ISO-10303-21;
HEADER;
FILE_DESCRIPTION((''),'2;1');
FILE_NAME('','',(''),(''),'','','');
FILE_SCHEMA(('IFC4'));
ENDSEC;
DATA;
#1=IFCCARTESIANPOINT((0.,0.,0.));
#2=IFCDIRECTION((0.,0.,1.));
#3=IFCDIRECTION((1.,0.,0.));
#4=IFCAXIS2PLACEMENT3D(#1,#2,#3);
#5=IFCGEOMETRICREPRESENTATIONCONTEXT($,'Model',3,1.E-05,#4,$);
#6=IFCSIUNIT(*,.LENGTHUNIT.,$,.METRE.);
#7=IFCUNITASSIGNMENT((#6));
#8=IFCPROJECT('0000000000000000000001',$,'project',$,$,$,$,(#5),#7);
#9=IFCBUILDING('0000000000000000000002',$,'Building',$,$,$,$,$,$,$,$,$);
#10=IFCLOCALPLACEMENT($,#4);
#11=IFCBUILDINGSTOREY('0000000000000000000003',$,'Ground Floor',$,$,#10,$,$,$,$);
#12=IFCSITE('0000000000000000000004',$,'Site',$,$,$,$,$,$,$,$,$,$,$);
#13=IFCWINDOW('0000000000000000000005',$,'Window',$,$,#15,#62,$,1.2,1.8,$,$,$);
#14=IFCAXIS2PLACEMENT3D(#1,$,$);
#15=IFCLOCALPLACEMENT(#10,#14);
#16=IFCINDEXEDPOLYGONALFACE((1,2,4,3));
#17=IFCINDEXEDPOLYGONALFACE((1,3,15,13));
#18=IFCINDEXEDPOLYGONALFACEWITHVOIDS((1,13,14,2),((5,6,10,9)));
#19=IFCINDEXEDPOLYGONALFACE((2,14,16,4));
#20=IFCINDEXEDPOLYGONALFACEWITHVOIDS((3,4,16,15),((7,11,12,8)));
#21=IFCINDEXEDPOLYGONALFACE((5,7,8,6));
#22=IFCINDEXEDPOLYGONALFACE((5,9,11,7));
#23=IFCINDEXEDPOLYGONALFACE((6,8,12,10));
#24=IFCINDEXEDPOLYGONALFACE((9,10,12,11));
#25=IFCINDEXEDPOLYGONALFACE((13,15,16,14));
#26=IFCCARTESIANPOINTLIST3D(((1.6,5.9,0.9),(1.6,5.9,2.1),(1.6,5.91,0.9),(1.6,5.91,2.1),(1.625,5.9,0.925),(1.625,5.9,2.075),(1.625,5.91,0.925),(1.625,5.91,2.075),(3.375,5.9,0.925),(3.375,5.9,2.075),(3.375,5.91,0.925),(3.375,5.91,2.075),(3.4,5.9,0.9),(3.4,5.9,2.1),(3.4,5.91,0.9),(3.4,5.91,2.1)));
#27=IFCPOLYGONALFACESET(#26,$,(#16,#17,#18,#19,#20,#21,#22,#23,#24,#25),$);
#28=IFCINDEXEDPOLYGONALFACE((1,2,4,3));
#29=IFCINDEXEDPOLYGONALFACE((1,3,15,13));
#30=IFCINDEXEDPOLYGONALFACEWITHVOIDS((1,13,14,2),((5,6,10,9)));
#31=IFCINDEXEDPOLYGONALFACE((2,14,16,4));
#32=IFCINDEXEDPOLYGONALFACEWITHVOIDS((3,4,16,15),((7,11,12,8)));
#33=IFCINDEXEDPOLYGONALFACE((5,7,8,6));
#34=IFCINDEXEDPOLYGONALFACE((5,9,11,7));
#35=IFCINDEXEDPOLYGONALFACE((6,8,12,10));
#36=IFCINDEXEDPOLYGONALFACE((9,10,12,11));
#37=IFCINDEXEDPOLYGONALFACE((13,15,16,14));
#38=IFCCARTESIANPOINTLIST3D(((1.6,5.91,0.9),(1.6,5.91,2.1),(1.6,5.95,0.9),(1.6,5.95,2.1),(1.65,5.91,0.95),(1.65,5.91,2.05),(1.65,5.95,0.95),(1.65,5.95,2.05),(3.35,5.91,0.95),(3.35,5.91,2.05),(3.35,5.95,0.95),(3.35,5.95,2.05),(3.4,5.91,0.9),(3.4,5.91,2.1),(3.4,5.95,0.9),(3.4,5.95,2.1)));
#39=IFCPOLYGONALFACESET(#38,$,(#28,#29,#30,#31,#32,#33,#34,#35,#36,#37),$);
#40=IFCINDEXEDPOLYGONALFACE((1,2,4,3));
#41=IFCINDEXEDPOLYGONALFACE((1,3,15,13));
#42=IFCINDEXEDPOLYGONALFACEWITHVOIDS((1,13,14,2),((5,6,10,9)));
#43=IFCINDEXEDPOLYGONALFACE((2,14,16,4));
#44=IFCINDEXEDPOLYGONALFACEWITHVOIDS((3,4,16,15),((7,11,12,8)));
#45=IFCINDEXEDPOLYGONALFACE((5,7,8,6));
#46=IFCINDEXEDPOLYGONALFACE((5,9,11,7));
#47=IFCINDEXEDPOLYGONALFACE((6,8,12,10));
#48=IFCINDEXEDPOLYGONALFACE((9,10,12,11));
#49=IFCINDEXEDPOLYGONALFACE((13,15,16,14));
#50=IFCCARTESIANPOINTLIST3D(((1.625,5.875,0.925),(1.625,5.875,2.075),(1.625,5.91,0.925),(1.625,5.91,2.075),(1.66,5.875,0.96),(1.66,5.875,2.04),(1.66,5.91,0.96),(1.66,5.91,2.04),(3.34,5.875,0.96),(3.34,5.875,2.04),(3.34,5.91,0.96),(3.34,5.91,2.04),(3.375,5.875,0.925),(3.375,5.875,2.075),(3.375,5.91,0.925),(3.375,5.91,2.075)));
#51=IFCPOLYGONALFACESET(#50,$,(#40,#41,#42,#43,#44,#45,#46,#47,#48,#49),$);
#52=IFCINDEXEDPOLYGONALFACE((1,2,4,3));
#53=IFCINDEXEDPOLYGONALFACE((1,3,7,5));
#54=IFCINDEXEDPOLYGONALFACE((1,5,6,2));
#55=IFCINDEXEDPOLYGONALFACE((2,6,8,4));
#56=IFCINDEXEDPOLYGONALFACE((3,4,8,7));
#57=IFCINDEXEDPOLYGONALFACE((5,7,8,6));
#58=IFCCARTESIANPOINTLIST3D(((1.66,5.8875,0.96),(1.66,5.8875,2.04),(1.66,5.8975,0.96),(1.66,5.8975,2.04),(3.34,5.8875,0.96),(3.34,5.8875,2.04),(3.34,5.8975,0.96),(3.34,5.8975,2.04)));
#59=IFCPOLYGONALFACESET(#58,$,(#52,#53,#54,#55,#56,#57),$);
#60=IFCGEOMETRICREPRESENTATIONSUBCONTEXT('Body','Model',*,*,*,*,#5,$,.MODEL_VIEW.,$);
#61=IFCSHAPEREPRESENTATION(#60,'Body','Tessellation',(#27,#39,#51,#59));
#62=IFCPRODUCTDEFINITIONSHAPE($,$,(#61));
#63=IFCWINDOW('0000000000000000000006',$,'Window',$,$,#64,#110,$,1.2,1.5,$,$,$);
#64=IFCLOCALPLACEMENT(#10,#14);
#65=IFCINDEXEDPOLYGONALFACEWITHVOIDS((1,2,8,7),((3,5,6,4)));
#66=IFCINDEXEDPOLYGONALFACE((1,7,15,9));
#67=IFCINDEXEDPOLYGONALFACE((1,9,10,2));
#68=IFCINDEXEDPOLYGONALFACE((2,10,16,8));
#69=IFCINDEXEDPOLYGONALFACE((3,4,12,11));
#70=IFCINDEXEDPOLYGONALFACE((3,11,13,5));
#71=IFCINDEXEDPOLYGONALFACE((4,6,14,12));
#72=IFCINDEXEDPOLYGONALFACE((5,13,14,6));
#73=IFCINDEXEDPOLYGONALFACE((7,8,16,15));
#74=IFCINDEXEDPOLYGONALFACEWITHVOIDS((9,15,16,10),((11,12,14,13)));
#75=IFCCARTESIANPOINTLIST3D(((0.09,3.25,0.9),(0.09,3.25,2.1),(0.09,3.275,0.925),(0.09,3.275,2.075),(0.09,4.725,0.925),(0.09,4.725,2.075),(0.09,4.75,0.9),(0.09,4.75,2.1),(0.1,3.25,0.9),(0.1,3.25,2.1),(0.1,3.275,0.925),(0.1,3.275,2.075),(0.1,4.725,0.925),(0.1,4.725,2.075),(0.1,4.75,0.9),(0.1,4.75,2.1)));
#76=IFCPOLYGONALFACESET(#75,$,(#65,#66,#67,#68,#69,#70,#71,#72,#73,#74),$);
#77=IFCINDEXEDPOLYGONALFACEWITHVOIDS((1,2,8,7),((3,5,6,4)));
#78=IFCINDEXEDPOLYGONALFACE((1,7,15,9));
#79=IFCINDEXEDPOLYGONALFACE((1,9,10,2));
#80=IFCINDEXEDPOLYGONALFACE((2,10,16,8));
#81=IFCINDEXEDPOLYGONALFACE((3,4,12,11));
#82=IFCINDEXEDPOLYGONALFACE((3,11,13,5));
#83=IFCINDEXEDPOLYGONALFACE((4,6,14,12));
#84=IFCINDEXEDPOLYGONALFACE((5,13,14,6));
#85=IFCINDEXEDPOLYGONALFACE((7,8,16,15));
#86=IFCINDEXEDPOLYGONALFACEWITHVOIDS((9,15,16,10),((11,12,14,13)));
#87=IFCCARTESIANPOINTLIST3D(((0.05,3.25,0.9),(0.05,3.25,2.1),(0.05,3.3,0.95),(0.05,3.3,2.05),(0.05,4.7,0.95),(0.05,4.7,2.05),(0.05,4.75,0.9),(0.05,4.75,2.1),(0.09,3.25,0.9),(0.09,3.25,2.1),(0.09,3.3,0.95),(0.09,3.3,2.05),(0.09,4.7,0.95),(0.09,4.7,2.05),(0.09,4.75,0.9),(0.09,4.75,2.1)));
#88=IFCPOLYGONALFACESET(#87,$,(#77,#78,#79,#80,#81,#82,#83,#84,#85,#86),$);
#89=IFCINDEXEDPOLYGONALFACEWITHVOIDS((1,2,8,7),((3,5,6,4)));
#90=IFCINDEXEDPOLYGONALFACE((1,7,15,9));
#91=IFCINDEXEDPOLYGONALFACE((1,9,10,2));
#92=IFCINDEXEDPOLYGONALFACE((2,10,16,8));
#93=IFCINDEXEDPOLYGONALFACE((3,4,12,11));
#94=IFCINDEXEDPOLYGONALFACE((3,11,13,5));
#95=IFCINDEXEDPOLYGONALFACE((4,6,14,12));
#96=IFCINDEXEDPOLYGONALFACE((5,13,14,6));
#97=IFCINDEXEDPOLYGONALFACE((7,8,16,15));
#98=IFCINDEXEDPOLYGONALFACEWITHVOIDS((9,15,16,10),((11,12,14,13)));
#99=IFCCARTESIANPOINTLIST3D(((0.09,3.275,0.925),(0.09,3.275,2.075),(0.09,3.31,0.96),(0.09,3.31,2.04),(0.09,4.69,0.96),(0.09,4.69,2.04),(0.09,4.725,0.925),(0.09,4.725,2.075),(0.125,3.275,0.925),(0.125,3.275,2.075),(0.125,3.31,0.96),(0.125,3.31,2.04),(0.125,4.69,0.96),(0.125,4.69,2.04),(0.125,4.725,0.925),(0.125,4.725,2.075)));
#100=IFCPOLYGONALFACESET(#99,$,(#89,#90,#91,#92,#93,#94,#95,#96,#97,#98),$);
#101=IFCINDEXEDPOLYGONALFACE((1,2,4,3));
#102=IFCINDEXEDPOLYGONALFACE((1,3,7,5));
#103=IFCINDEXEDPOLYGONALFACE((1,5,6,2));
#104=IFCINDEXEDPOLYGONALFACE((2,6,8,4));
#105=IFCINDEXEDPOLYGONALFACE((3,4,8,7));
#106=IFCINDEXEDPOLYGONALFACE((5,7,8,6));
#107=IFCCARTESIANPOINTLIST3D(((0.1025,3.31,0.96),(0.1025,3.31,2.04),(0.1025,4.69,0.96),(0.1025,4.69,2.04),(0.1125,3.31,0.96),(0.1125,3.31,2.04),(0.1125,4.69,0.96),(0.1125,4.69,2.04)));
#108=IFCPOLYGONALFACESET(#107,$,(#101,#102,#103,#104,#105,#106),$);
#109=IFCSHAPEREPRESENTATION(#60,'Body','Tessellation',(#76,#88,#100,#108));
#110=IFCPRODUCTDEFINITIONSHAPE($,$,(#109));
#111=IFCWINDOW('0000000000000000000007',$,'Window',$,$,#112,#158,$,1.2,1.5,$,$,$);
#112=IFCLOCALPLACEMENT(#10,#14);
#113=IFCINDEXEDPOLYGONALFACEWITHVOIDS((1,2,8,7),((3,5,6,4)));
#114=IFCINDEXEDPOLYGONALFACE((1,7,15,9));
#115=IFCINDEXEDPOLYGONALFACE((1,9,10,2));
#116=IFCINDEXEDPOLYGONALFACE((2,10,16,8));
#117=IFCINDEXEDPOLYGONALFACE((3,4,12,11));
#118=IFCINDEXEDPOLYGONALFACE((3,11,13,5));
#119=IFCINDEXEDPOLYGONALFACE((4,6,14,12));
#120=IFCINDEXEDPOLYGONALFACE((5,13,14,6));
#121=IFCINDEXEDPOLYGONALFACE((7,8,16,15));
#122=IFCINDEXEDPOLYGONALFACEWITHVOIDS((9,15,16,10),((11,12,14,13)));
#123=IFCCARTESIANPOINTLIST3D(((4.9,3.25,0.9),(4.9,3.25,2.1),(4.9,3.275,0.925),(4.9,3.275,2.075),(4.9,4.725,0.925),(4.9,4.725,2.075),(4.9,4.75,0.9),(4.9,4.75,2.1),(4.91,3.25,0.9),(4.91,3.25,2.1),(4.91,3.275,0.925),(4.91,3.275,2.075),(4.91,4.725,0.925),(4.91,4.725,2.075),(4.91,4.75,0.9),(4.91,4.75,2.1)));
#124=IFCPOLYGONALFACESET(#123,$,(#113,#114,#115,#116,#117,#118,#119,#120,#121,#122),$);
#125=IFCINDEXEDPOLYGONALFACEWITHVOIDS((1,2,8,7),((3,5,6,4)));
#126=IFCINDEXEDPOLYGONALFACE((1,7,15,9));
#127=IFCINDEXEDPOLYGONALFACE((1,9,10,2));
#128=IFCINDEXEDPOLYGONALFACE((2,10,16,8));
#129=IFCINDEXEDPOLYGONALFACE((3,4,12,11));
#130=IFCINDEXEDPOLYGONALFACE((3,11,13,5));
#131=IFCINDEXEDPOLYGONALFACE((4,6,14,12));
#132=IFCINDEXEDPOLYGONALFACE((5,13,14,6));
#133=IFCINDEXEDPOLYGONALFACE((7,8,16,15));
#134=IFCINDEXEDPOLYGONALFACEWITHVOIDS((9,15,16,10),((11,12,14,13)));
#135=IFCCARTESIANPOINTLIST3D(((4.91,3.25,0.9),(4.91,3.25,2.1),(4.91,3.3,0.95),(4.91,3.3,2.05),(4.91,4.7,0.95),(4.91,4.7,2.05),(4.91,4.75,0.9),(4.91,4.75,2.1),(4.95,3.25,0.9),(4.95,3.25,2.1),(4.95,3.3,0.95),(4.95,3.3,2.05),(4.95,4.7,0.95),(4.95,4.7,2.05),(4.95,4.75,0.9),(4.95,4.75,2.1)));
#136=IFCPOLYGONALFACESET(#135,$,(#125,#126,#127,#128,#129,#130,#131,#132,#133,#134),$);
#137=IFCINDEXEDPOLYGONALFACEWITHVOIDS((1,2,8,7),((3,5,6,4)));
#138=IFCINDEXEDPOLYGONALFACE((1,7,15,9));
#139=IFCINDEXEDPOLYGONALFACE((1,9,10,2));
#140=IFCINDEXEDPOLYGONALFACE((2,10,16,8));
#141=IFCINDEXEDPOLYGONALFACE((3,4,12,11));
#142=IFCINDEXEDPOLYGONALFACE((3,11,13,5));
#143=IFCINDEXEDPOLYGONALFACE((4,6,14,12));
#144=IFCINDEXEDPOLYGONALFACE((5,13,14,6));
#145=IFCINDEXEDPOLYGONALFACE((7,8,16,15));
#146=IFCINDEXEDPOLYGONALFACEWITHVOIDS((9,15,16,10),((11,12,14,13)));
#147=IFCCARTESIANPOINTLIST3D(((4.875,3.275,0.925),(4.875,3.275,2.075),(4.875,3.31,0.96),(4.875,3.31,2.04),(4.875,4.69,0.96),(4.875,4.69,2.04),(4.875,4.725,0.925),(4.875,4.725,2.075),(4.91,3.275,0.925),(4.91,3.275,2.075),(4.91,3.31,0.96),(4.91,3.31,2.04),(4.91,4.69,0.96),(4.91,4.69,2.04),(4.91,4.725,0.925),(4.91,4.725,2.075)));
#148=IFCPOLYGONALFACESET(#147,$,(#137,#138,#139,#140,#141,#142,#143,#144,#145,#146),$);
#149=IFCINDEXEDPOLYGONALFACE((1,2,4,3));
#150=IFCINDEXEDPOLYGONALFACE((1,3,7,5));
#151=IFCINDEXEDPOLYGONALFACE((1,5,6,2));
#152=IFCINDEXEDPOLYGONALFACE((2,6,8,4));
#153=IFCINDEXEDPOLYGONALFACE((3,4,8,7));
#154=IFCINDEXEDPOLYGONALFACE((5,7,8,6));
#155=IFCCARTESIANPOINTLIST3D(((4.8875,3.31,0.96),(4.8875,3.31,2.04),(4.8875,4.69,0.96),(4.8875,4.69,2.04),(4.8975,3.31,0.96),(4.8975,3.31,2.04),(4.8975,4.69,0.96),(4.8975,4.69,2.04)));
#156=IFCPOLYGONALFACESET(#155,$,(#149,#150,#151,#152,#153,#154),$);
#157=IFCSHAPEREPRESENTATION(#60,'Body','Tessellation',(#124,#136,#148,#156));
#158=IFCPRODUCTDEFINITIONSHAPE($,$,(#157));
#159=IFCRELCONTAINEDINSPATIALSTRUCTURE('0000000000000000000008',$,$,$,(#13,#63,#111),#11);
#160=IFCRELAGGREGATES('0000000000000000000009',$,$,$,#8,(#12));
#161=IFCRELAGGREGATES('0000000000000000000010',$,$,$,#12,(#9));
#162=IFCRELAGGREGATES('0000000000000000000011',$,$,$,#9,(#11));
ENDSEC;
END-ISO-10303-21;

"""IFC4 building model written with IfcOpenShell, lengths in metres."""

from ifc_helpers import new_model, si_unit, frame, origin_with_axes, place, context, subcontext, project, spatial, line, indexed_curve, outline, extrude, element, save


model = new_model("IFC4")

# Units and contexts
model_context = context("Model", 3, precision=1e-05, world=origin_with_axes())
body_context = subcontext(model_context, "Body", "Model", "MODEL_VIEW")
ifc_project = project(units=[si_unit("LENGTHUNIT", "METRE")], contexts=[model_context])

# Site, building, storey
site = spatial("IfcSite", under=ifc_project, Name="Site")
building = spatial("IfcBuilding", under=site, Name="Building")
storey_placement = place(None, origin_with_axes())
storey = spatial("IfcBuildingStorey", under=building, at=storey_placement, Name="Ground Floor")

# Windows
window_placement = place(storey_placement, frame((3.4, 6.0, 0.9), z_axis=(0.0, 0.0, 1.0), x_axis=(-1.0, 0.0, 0.0)))
element("IfcWindow", 1, at=window_placement, inside=storey, Name="Window", OverallHeight=1.2, OverallWidth=1.8, context=body_context, shape_type="SweptSolid", body=[
    extrude(outline(indexed_curve([(0.0, 0.0), (1.8, 0.0), (1.8, 1.2), (0.0, 1.2)], segments=[line(1, 2, 3, 4, 1)]), holes=[indexed_curve([(0.025, 0.025), (1.775, 0.025), (1.775, 1.175), (0.025, 1.175)], segments=[line(1, 2, 3, 4, 1)])]), frame((0.0, 0.09, 0.0), z_axis=(0.0, -1.0, 0.0), x_axis=(1.0, 0.0, 0.0)), (0.0, 0.0, -1.0), 0.01),
    extrude(outline(indexed_curve([(0.0, 0.0), (1.8, 0.0), (1.8, 1.2), (0.0, 1.2)], segments=[line(1, 2, 3, 4, 1)]), holes=[indexed_curve([(0.05, 0.05), (1.75, 0.05), (1.75, 1.15), (0.05, 1.15)], segments=[line(1, 2, 3, 4, 1)])]), frame((0.0, 0.05, 0.0), z_axis=(0.0, -1.0, 0.0), x_axis=(1.0, 0.0, 0.0)), (0.0, 0.0, -1.0), 0.04),
    extrude(outline(indexed_curve([(0.0, 0.0), (1.75, 0.0), (1.75, 1.15), (0.0, 1.15)], segments=[line(1, 2, 3, 4, 1)]), holes=[indexed_curve([(0.035, 0.035), (1.715, 0.035), (1.715, 1.115), (0.035, 1.115)], segments=[line(1, 2, 3, 4, 1)])]), frame((0.025, 0.09, 0.025), z_axis=(0.0, -1.0, 0.0), x_axis=(1.0, 0.0, 0.0)), (0.0, 0.0, -1.0), 0.035),
    extrude(outline(indexed_curve([(0.035, 0.035), (1.715, 0.035), (1.715, 1.115), (0.035, 1.115)], segments=[line(1, 2, 3, 4, 1)])), frame((0.025, 0.1025, 0.025), z_axis=(0.0, -1.0, 0.0), x_axis=(1.0, 0.0, 0.0)), (0.0, 0.0, -1.0), 0.01),
])
for number, where, z_axis, x_axis, name in (
    (2, (0.0, 4.75, 0.9), (0.0, 0.0, 1.0), (0.0, -1.0, 0.0), "Window"),
    (3, (5.0, 3.25, 0.9), (0.0, 0.0, 1.0), (0.0, 1.0, 0.0), "Window"),
):
    element("IfcWindow", number, at=place(storey_placement, frame(where, z_axis=z_axis, x_axis=x_axis)), inside=storey, Name=name, OverallHeight=1.2, OverallWidth=1.5, context=body_context, shape_type="SweptSolid", body=[
        extrude(outline(indexed_curve([(0.0, 0.0), (1.5, 0.0), (1.5, 1.2), (0.0, 1.2)], segments=[line(1, 2, 3, 4, 1)]), holes=[indexed_curve([(0.025, 0.025), (1.475, 0.025), (1.475, 1.175), (0.025, 1.175)], segments=[line(1, 2, 3, 4, 1)])]), frame((0.0, 0.09, 0.0), z_axis=(0.0, -1.0, 0.0), x_axis=(1.0, 0.0, 0.0)), (0.0, 0.0, -1.0), 0.01),
        extrude(outline(indexed_curve([(0.0, 0.0), (1.5, 0.0), (1.5, 1.2), (0.0, 1.2)], segments=[line(1, 2, 3, 4, 1)]), holes=[indexed_curve([(0.05, 0.05), (1.45, 0.05), (1.45, 1.15), (0.05, 1.15)], segments=[line(1, 2, 3, 4, 1)])]), frame((0.0, 0.05, 0.0), z_axis=(0.0, -1.0, 0.0), x_axis=(1.0, 0.0, 0.0)), (0.0, 0.0, -1.0), 0.04),
        extrude(outline(indexed_curve([(0.0, 0.0), (1.45, 0.0), (1.45, 1.15), (0.0, 1.15)], segments=[line(1, 2, 3, 4, 1)]), holes=[indexed_curve([(0.035, 0.035), (1.415, 0.035), (1.415, 1.115), (0.035, 1.115)], segments=[line(1, 2, 3, 4, 1)])]), frame((0.025, 0.09, 0.025), z_axis=(0.0, -1.0, 0.0), x_axis=(1.0, 0.0, 0.0)), (0.0, 0.0, -1.0), 0.035),
        extrude(outline(indexed_curve([(0.035, 0.035), (1.415, 0.035), (1.415, 1.115), (0.035, 1.115)], segments=[line(1, 2, 3, 4, 1)])), frame((0.025, 0.1025, 0.025), z_axis=(0.0, -1.0, 0.0), x_axis=(1.0, 0.0, 0.0)), (0.0, 0.0, -1.0), 0.01),
    ])

save(model, "model.ifc")
